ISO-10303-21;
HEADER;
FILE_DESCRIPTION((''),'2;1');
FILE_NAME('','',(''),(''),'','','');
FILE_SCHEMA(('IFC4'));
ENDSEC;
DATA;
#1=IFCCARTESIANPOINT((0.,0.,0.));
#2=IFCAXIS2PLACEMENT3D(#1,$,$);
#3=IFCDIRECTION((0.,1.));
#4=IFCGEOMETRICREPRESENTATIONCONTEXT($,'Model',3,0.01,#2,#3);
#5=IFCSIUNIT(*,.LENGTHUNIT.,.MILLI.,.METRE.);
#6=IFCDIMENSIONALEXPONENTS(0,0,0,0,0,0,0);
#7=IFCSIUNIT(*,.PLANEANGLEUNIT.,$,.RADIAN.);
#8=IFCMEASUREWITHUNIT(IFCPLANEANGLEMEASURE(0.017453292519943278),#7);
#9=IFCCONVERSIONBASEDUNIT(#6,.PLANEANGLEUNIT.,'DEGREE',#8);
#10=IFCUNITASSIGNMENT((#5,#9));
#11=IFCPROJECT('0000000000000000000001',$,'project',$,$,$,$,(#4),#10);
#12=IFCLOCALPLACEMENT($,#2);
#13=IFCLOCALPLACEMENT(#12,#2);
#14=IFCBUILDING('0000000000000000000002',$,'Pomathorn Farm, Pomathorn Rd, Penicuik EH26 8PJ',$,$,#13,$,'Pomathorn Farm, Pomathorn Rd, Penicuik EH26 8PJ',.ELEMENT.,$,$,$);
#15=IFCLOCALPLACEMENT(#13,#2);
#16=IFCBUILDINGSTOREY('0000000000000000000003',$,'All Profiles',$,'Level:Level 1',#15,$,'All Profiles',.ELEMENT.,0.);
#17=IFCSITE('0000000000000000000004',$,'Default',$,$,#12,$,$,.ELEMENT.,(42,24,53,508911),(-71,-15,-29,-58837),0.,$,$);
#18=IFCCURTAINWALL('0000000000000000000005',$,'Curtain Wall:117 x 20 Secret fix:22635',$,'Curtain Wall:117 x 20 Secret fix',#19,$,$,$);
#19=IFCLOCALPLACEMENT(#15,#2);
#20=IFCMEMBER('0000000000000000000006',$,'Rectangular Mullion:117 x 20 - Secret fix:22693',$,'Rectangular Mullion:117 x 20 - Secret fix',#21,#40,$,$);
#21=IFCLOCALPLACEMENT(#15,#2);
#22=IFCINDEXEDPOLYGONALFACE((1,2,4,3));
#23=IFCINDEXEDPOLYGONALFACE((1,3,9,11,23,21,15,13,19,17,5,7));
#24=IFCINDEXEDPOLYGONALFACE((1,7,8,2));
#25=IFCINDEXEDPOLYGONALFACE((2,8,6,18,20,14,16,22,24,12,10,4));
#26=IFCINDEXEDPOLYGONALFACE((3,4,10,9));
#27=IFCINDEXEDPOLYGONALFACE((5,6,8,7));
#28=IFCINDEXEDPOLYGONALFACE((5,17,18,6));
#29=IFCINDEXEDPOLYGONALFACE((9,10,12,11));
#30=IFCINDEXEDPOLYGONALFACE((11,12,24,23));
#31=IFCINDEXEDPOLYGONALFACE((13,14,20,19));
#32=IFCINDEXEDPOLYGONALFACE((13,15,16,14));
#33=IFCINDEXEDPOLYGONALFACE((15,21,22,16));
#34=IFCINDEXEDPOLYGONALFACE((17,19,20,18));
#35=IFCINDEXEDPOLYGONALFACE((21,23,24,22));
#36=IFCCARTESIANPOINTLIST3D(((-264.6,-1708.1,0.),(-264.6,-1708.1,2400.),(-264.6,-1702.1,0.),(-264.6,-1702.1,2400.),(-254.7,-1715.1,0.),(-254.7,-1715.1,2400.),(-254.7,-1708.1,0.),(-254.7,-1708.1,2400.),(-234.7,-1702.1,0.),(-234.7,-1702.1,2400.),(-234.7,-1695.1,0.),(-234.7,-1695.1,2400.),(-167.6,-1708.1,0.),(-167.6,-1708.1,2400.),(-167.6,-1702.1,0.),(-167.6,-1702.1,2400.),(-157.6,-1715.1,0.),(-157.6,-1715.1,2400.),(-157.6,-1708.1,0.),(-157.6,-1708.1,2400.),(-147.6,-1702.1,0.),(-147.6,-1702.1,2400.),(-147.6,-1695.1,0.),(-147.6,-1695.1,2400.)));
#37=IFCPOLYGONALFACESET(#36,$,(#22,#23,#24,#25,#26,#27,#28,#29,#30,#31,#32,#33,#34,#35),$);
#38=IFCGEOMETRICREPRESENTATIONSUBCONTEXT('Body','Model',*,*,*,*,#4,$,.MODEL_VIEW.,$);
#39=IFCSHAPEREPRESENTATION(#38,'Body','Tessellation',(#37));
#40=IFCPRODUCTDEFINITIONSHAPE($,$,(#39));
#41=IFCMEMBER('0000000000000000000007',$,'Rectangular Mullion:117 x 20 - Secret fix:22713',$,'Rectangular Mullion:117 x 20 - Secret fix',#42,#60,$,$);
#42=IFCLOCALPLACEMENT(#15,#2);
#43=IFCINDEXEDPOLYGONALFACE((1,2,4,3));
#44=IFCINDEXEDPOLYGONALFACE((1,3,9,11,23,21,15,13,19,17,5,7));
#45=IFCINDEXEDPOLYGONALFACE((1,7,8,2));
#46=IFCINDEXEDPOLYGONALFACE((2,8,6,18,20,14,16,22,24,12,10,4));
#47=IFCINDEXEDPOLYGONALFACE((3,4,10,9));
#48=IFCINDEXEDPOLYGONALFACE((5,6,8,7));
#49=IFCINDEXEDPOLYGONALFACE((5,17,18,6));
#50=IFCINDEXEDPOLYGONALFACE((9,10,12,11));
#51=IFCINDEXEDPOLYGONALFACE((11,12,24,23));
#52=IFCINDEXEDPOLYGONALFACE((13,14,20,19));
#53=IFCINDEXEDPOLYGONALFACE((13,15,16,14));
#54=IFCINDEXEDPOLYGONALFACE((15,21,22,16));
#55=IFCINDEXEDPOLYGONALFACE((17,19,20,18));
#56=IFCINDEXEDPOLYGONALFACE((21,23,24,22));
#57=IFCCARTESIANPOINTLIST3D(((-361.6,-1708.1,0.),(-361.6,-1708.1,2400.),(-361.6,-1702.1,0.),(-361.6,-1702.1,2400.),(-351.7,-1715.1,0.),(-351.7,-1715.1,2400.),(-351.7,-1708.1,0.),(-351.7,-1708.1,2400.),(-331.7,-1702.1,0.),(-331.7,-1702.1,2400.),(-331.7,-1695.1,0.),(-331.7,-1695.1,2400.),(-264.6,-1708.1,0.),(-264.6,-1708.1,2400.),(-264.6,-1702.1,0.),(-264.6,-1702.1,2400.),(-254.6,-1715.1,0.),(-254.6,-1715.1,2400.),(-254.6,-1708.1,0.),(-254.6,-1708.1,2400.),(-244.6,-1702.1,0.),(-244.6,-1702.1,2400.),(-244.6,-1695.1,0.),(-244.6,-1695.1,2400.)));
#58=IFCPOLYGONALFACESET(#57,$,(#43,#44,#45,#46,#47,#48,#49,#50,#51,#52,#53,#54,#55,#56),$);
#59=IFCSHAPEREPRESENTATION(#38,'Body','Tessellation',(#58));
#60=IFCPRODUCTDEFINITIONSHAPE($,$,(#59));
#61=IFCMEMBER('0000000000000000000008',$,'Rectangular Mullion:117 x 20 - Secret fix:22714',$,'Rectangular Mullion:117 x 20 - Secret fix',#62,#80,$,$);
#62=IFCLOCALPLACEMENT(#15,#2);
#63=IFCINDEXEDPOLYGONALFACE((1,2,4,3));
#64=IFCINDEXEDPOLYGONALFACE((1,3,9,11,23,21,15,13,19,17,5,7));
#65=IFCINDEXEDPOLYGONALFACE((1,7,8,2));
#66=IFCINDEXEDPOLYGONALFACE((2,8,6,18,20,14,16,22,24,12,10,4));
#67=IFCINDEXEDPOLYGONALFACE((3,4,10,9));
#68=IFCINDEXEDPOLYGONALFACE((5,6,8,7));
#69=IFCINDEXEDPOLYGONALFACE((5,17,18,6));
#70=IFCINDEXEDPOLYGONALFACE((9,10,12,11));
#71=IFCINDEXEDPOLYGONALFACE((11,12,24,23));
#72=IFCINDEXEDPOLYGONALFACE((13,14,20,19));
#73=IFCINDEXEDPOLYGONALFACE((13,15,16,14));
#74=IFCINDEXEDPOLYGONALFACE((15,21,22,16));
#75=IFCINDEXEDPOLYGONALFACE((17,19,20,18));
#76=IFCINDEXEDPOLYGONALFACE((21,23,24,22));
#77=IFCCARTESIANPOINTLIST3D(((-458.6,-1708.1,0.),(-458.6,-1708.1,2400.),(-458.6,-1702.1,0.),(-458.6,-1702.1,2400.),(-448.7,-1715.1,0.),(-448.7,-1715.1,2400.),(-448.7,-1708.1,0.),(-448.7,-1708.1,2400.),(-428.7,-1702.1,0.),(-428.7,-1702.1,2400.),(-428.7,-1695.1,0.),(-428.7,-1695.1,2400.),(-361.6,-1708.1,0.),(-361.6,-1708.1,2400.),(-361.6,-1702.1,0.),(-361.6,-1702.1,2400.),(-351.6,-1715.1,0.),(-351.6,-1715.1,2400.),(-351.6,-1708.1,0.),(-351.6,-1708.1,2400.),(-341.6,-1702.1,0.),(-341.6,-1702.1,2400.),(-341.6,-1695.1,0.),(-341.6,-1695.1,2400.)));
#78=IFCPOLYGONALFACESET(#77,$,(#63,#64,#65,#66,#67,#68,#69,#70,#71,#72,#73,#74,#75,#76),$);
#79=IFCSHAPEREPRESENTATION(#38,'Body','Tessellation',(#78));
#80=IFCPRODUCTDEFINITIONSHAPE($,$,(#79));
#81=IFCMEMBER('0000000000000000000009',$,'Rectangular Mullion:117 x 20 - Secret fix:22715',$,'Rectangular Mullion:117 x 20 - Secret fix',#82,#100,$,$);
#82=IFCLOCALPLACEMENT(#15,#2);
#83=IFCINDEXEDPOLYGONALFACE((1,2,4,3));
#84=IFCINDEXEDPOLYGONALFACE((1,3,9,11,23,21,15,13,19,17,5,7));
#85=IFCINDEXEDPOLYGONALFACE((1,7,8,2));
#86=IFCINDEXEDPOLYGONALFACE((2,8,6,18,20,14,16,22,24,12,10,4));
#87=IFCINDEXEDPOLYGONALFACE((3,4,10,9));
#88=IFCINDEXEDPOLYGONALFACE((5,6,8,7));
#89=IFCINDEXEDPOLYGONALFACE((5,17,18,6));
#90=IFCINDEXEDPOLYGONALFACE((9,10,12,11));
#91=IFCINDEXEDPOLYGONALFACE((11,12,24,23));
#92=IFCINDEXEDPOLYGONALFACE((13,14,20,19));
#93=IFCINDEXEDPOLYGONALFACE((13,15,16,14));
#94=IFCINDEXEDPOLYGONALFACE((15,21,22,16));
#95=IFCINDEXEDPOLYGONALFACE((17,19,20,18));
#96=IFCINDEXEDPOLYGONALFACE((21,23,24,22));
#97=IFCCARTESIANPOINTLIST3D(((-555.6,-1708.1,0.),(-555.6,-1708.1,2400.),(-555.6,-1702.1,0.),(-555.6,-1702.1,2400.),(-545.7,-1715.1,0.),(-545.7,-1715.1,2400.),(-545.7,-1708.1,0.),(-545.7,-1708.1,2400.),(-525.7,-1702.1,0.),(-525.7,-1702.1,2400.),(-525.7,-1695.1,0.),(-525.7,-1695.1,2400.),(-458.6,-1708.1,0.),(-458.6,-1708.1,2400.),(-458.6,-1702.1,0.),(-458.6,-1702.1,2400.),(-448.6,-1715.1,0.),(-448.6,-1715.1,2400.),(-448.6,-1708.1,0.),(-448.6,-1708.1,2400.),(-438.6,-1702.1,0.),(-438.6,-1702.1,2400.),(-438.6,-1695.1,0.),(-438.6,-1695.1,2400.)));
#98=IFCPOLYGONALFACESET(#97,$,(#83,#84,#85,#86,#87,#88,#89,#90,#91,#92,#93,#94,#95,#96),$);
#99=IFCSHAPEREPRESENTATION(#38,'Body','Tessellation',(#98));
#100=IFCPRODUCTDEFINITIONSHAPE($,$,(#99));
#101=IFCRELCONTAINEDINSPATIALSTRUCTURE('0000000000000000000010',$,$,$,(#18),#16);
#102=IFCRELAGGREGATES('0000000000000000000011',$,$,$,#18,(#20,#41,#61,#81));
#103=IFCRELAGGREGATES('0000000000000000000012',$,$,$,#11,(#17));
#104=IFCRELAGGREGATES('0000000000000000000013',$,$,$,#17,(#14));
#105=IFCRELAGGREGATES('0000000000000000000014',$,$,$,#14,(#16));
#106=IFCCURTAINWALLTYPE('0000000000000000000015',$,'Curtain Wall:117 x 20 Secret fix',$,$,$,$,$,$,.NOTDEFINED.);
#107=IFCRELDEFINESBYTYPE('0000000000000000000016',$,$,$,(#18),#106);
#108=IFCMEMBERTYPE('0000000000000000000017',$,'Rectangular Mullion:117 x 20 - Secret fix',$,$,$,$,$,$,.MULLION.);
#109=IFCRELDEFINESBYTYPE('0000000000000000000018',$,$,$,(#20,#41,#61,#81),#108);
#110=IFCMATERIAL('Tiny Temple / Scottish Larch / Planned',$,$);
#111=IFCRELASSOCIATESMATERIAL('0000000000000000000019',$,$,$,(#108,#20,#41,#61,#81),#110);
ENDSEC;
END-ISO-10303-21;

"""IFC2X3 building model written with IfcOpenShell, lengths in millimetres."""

from ifc_helpers import new_model, entity, si_unit, converted_unit, direction, frame, origin, place, context, subcontext, project, spatial, polyline, outline, extrude, source, transform, mapped, material, type_object, type_shapes, element, aggregate, save


model = new_model("IFC2X3")

# Units and contexts
model_context = context("Model", 3, precision=0.01, world=origin(), true_north=direction((0.0, 1.0)))
body_context = subcontext(model_context, "Body", "Model", "MODEL_VIEW")
ifc_project = project(units=[si_unit("LENGTHUNIT", "METRE", prefix="MILLI"), converted_unit("PLANEANGLEUNIT", "DEGREE", entity("IfcPlaneAngleMeasure", 0.017453292519943278), si_unit("PLANEANGLEUNIT", "RADIAN"), dimensions=[0, 0, 0, 0, 0, 0, 0])], contexts=[model_context])

# Site, building, storey
site_placement = place(None, origin())
site = spatial("IfcSite", under=ifc_project, at=site_placement, Name="Default", CompositionType="ELEMENT", RefLatitude=(42, 24, 53, 508911), RefLongitude=(-71, -15, -29, -58837), RefElevation=0.0)
building_placement = place(site_placement, origin())
building = spatial("IfcBuilding", under=site, at=building_placement, Name="Pomathorn Farm, Pomathorn Rd, Penicuik EH26 8PJ", LongName="Pomathorn Farm, Pomathorn Rd, Penicuik EH26 8PJ", CompositionType="ELEMENT")
storey_placement = place(building_placement, origin())
storey = spatial("IfcBuildingStorey", under=building, at=storey_placement, Name="All Profiles", ObjectType="Level:Level 1", LongName="All Profiles", CompositionType="ELEMENT", Elevation=0.0)

# Curtain wall, members
curtain_wall_type_1 = type_object("IfcCurtainWallType", Name="Curtain Wall:117 x 20 Secret fix", PredefinedType="NOTDEFINED")
curtain_wall_1_placement = place(storey_placement, origin())
curtain_wall_1 = element("IfcCurtainWall", 1, at=curtain_wall_1_placement, inside=storey, type_object=curtain_wall_type_1, Name="Curtain Wall:117 x 20 Secret fix:22635", ObjectType="Curtain Wall:117 x 20 Secret fix")
ifc_material = material(Name="Tiny Temple / Scottish Larch / Planned")
member_type_1 = type_object("IfcMemberType", Name="Rectangular Mullion:117 x 20 - Secret fix", PredefinedType="MULLION", material=ifc_material)
shared_shape_1 = source(origin(), body_context, "Body", "SweptSolid", [
    extrude(outline(polyline([(-3.0, -60.2), (3.0, -60.2), (3.0, -30.2), (10.0, -30.2), (10.0, 56.8), (3.0, 56.8), (3.0, 36.8), (-3.0, 36.8), (-3.0, 46.8), (-10.0, 46.8), (-10.0, -50.2), (-3.0, -50.2), (-3.0, -60.2)])), frame((-56.8, -10.0, -2400.0), z_axis=(0.0, 0.0, 1.0), x_axis=(0.0, -1.0, 0.0)), (0.0, 0.0, 1.0), 2400.0),
])
type_shapes(member_type_1, [shared_shape_1])
member_1_placement = place(curtain_wall_1_placement, frame((-147.6, -1715.1, 0.0), z_axis=(0.0, 0.0, -1.0), x_axis=(1.0, 0.0, 0.0)))
member_1 = element("IfcMember", 2, at=member_1_placement, type_object=member_type_1, material=ifc_material, Name="Rectangular Mullion:117 x 20 - Secret fix:22693", ObjectType="Rectangular Mullion:117 x 20 - Secret fix", context=body_context, shape_type="MappedRepresentation", body=[
    mapped(shared_shape_1, transform((0.0, 0.0, 0.0), scale=1.0)),
])
member_2_placement = place(curtain_wall_1_placement, frame((-244.6, -1715.1, 0.0), z_axis=(0.0, 0.0, -1.0), x_axis=(1.0, 0.0, 0.0)))
member_2 = element("IfcMember", 3, at=member_2_placement, type_object=member_type_1, material=ifc_material, Name="Rectangular Mullion:117 x 20 - Secret fix:22713", ObjectType="Rectangular Mullion:117 x 20 - Secret fix", context=body_context, shape_type="MappedRepresentation", body=[
    mapped(shared_shape_1, transform((0.0, 0.0, 0.0), scale=1.0)),
])
member_3_placement = place(curtain_wall_1_placement, frame((-341.6, -1715.1, 0.0), z_axis=(0.0, 0.0, -1.0), x_axis=(1.0, 0.0, 0.0)))
member_3 = element("IfcMember", 4, at=member_3_placement, type_object=member_type_1, material=ifc_material, Name="Rectangular Mullion:117 x 20 - Secret fix:22714", ObjectType="Rectangular Mullion:117 x 20 - Secret fix", context=body_context, shape_type="MappedRepresentation", body=[
    mapped(shared_shape_1, transform((0.0, 0.0, 0.0), scale=1.0)),
])
member_4_placement = place(curtain_wall_1_placement, frame((-438.6, -1715.1, 0.0), z_axis=(0.0, 0.0, -1.0), x_axis=(1.0, 0.0, 0.0)))
member_4 = element("IfcMember", 5, at=member_4_placement, type_object=member_type_1, material=ifc_material, Name="Rectangular Mullion:117 x 20 - Secret fix:22715", ObjectType="Rectangular Mullion:117 x 20 - Secret fix", context=body_context, shape_type="MappedRepresentation", body=[
    mapped(shared_shape_1, transform((0.0, 0.0, 0.0), scale=1.0)),
])
aggregate(curtain_wall_1, [member_1, member_2, member_3, member_4])

save(model, "model.ifc")
